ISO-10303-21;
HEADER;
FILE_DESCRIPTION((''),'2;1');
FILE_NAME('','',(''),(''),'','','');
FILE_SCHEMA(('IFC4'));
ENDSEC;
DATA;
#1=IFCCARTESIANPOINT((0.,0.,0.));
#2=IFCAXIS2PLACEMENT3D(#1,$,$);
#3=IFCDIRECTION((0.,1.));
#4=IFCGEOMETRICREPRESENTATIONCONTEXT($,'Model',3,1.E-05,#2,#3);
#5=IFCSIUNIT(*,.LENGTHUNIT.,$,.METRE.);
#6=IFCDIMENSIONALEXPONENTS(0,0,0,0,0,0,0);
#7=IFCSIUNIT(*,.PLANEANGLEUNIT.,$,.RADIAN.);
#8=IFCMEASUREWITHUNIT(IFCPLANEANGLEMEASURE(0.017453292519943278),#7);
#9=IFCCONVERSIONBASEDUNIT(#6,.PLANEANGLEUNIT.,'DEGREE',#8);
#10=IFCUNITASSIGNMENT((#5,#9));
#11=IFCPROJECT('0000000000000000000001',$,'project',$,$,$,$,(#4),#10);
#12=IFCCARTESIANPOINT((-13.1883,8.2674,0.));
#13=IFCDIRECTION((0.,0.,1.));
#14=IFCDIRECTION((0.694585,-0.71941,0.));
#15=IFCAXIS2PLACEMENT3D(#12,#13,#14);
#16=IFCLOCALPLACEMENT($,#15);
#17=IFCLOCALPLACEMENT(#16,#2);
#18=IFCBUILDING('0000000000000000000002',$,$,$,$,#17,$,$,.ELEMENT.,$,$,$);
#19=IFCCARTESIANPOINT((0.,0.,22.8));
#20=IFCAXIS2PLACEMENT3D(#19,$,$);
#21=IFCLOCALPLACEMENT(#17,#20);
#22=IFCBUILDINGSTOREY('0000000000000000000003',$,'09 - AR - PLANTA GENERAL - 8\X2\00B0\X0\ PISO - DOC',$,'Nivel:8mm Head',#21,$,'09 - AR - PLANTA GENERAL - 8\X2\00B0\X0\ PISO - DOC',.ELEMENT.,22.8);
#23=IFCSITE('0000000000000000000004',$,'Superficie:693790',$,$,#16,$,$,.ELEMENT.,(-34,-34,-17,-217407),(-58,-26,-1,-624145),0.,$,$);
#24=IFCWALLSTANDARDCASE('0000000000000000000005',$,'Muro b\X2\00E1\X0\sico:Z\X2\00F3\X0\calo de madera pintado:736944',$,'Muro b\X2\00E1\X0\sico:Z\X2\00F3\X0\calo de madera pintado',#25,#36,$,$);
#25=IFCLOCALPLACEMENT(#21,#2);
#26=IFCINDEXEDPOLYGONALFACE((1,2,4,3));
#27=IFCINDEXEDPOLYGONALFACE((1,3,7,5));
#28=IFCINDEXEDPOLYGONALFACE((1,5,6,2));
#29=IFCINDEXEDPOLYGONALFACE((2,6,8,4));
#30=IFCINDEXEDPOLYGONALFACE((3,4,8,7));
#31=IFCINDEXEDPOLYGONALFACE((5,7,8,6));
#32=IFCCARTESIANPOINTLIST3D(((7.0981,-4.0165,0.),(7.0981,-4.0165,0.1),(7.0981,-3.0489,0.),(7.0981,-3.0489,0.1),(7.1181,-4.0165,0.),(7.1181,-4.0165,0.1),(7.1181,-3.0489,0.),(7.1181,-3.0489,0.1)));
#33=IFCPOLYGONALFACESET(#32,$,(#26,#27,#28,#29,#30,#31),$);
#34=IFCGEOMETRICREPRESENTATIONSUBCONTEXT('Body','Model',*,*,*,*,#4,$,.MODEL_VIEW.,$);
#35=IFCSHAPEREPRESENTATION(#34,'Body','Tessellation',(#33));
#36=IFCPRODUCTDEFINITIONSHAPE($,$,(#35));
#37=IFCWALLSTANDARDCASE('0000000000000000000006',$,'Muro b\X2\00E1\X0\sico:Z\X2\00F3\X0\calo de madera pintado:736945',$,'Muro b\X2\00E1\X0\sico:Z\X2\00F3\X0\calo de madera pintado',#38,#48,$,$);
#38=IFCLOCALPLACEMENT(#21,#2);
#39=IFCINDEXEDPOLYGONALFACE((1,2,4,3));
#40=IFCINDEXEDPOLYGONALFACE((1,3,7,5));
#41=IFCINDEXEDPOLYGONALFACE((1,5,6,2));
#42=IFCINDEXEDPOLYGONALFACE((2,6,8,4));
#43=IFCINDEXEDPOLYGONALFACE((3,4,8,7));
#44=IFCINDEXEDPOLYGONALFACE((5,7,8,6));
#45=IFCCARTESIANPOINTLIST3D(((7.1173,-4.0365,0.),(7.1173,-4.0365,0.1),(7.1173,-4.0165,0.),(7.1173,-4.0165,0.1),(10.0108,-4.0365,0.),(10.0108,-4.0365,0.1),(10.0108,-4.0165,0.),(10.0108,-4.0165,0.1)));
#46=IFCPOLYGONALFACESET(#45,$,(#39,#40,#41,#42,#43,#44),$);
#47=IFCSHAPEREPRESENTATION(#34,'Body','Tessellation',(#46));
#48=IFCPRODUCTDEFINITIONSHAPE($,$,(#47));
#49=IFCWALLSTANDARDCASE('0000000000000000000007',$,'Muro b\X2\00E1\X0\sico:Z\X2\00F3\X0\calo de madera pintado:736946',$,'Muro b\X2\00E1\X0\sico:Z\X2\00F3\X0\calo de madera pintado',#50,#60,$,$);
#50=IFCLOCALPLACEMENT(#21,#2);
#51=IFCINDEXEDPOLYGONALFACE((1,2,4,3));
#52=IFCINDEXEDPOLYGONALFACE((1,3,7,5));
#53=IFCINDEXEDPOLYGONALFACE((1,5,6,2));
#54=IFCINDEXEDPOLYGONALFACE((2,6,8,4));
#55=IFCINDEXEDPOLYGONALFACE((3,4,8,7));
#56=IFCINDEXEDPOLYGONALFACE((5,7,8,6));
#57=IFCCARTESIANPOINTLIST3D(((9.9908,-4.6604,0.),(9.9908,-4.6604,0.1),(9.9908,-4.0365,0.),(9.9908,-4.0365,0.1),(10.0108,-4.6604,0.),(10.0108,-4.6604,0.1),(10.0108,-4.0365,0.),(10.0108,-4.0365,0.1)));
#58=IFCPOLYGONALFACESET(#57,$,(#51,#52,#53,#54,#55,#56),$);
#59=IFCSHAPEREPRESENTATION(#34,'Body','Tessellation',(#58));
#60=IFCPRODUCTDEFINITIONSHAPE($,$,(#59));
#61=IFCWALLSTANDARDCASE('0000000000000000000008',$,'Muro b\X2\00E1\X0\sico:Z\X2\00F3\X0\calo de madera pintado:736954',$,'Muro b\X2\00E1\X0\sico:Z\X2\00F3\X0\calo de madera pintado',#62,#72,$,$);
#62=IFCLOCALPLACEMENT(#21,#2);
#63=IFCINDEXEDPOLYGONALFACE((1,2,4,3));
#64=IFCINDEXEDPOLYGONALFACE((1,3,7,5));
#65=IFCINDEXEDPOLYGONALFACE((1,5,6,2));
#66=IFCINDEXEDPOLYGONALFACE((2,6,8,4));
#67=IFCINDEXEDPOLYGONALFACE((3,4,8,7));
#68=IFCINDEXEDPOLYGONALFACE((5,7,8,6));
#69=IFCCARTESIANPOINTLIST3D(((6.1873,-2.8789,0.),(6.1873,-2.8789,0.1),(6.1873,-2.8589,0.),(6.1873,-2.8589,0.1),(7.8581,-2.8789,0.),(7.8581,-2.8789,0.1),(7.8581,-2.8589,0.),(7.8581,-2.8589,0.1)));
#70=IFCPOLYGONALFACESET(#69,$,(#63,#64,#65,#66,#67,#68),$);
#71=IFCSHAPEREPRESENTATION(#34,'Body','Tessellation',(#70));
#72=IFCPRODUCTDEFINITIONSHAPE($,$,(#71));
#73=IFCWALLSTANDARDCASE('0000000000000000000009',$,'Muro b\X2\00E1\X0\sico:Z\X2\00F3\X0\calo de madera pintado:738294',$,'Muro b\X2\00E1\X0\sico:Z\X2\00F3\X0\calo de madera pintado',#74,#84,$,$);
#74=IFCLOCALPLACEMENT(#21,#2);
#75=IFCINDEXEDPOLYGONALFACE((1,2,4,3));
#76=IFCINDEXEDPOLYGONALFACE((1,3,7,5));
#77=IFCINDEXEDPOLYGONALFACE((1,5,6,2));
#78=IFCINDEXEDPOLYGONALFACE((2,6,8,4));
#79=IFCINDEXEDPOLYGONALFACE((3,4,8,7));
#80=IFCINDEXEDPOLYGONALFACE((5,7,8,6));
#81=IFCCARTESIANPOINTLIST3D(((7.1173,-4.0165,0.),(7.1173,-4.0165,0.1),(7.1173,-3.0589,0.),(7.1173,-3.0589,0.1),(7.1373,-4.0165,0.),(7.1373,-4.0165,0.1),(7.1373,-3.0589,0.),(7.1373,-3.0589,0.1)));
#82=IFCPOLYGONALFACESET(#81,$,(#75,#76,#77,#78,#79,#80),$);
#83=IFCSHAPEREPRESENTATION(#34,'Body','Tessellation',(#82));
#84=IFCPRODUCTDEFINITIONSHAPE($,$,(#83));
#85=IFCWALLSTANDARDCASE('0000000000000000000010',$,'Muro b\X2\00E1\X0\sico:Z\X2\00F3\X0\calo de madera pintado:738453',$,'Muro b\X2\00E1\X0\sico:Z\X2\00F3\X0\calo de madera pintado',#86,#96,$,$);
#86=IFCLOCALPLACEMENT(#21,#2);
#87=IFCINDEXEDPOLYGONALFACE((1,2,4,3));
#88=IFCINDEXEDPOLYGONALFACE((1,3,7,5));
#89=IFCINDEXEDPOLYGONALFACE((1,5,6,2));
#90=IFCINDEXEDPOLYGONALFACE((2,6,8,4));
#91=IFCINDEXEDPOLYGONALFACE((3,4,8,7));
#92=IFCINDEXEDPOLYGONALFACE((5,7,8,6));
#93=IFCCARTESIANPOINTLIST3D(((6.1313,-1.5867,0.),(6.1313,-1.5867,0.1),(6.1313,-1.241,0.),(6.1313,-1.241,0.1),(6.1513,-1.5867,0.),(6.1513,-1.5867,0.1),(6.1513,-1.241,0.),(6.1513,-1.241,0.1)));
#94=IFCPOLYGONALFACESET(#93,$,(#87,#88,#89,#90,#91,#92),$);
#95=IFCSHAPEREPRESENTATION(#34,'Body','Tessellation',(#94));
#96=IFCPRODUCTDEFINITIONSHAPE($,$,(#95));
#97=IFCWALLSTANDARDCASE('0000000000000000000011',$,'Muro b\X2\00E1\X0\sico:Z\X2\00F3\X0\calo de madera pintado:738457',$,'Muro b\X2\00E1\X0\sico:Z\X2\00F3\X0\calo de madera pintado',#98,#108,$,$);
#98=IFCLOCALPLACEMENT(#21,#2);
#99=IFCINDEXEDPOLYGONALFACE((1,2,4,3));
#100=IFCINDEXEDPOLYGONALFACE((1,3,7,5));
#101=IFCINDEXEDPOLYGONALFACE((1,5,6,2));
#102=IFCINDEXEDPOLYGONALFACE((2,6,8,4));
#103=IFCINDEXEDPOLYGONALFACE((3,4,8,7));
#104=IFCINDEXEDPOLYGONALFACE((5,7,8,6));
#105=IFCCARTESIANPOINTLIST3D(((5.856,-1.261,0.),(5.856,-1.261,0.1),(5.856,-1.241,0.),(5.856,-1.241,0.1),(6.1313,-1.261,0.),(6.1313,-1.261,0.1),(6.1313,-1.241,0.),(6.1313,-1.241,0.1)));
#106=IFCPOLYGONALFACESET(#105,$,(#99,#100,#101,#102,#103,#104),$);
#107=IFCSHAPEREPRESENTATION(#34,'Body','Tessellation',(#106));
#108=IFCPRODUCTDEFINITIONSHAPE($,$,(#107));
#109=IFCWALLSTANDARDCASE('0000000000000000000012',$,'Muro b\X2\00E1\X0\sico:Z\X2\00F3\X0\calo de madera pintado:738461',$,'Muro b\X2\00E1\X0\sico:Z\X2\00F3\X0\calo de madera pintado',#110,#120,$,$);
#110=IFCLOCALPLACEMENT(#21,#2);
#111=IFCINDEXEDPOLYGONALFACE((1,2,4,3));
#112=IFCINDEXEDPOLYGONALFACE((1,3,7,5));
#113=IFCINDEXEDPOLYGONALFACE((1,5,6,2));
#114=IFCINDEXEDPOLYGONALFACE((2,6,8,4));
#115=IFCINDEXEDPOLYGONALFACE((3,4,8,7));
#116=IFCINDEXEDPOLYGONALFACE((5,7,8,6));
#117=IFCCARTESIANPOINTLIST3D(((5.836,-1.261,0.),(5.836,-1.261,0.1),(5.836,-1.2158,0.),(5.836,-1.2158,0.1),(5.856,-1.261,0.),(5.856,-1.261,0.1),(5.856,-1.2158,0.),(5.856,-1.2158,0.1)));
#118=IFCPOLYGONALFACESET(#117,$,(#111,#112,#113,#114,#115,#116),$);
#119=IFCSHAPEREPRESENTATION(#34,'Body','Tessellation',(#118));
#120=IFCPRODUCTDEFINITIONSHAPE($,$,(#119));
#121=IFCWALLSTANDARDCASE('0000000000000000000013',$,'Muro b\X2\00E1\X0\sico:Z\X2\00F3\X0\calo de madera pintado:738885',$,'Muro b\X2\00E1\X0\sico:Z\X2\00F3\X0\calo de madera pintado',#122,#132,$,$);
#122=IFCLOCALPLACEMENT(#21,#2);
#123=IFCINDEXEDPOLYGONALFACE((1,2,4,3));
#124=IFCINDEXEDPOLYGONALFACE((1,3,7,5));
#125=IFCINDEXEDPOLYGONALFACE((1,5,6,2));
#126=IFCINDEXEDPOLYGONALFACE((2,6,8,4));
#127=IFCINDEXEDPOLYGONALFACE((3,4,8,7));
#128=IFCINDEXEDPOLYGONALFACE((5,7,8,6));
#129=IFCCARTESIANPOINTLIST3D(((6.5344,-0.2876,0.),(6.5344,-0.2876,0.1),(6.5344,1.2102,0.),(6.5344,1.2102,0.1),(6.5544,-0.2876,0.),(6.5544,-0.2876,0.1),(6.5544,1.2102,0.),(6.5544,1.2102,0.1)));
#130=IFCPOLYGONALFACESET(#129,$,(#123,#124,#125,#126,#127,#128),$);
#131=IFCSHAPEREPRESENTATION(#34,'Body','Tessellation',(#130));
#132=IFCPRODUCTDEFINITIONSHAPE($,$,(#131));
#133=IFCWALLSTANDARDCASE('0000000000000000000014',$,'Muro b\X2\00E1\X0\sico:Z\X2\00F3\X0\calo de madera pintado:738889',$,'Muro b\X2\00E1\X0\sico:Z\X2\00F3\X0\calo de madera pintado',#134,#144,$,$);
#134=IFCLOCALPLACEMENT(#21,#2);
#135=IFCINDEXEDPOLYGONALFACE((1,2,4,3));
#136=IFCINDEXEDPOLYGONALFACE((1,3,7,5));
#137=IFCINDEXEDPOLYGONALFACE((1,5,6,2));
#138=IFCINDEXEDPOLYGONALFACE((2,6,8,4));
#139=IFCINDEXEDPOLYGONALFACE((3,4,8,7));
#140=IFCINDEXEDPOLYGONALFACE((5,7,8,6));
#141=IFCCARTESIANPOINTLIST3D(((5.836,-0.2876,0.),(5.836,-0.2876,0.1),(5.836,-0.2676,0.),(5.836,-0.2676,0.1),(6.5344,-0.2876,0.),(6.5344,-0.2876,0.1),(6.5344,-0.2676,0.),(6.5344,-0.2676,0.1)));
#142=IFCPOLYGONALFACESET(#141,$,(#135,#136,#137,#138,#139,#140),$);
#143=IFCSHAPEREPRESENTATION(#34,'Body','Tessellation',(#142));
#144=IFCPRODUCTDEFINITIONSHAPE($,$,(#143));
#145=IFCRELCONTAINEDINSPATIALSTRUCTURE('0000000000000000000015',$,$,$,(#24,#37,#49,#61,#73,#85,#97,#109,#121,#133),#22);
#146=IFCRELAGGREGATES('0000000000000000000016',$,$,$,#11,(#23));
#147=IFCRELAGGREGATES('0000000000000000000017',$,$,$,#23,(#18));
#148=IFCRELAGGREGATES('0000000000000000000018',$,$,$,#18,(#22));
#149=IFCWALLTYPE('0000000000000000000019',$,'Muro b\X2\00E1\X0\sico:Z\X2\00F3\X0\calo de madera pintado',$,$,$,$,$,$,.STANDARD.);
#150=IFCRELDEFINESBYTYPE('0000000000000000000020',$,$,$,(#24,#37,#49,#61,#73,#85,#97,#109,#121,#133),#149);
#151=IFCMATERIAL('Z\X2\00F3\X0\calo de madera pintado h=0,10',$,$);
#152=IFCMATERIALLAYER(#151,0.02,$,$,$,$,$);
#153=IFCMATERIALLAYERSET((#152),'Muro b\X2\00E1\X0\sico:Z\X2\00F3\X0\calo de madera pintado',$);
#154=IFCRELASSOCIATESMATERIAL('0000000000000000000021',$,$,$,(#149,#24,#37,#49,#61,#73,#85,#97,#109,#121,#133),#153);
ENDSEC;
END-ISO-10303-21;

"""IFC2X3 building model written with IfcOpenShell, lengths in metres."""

from ifc_helpers import new_model, entity, si_unit, converted_unit, direction, frame, frame_2d, origin, place, context, subcontext, project, spatial, rectangle, extrude, material, layer, layer_set, layer_usage, type_object, element, save


model = new_model("IFC2X3")

# Units and contexts
model_context = context("Model", 3, precision=1e-05, world=origin(), true_north=direction((0.0, 1.0)))
body_context = subcontext(model_context, "Body", "Model", "MODEL_VIEW")
ifc_project = project(units=[si_unit("LENGTHUNIT", "METRE"), converted_unit("PLANEANGLEUNIT", "DEGREE", entity("IfcPlaneAngleMeasure", 0.017453292519943278), si_unit("PLANEANGLEUNIT", "RADIAN"), dimensions=[0, 0, 0, 0, 0, 0, 0])], contexts=[model_context])

# Site, building, storey
site_placement = place(None, frame((-13.1883, 8.2674, 0.0), z_axis=(0.0, 0.0, 1.0), x_axis=(0.694585, -0.71941, 0.0)))
site = spatial("IfcSite", under=ifc_project, at=site_placement, Name="Superficie:693790", CompositionType="ELEMENT", RefLatitude=(-34, -34, -17, -217407), RefLongitude=(-58, -26, -1, -624145), RefElevation=0.0)
building_placement = place(site_placement, origin())
building = spatial("IfcBuilding", under=site, at=building_placement, CompositionType="ELEMENT")
storey_placement = place(building_placement, frame((0.0, 0.0, 22.8)))
storey = spatial("IfcBuildingStorey", under=building, at=storey_placement, Name="09 - AR - PLANTA GENERAL - 8° PISO - DOC", ObjectType="Nivel:8mm Head", LongName="09 - AR - PLANTA GENERAL - 8° PISO - DOC", CompositionType="ELEMENT", Elevation=22.8)

# Walls
ifc_material_1 = material(Name="Zócalo de madera pintado h=0,10")
ifc_layer_1 = layer(ifc_material_1, 0.02)
ifc_layer_set_1 = layer_set([ifc_layer_1], Name="Muro básico:Zócalo de madera pintado")
wall_type_1 = type_object("IfcWallType", Name="Muro básico:Zócalo de madera pintado", PredefinedType="STANDARD", material=ifc_layer_set_1)
ifc_layer_usage_1 = layer_usage(ifc_layer_set_1, "AXIS2", "NEGATIVE", 0.01)
wall_1_placement = place(storey_placement, frame((7.1081, -4.0165, 0.0), z_axis=(0.0, 0.0, 1.0), x_axis=(0.0, 1.0, 0.0)))
element("IfcWallStandardCase", 1, at=wall_1_placement, inside=storey, type_object=wall_type_1, material=ifc_layer_usage_1, Name="Muro básico:Zócalo de madera pintado:736944", ObjectType="Muro básico:Zócalo de madera pintado", context=body_context, shape_type="SweptSolid", body=[
    extrude(rectangle(XDim=0.9676, YDim=0.02, at=frame_2d((0.4838, 0.0), x_axis=(-1.0, 0.0))), origin(), (0.0, 0.0, 1.0), 0.1),
])
ifc_layer_usage_2 = layer_usage(ifc_layer_set_1, "AXIS2", "NEGATIVE", 0.01)
wall_2_placement = place(storey_placement, frame((10.0108, -4.0265, 0.0), z_axis=(0.0, 0.0, 1.0), x_axis=(-1.0, 0.0, 0.0)))
element("IfcWallStandardCase", 2, at=wall_2_placement, inside=storey, type_object=wall_type_1, material=ifc_layer_usage_2, Name="Muro básico:Zócalo de madera pintado:736945", ObjectType="Muro básico:Zócalo de madera pintado", context=body_context, shape_type="SweptSolid", body=[
    extrude(rectangle(XDim=2.8934, YDim=0.02, at=frame_2d((1.4467, 0.0), x_axis=(-1.0, 0.0))), origin(), (0.0, 0.0, 1.0), 0.1),
])
ifc_layer_usage_3 = layer_usage(ifc_layer_set_1, "AXIS2", "NEGATIVE", 0.01)
wall_3_placement = place(storey_placement, frame((10.0008, -4.6604, 0.0), z_axis=(0.0, 0.0, 1.0), x_axis=(0.0, 1.0, 0.0)))
element("IfcWallStandardCase", 3, at=wall_3_placement, inside=storey, type_object=wall_type_1, material=ifc_layer_usage_3, Name="Muro básico:Zócalo de madera pintado:736946", ObjectType="Muro básico:Zócalo de madera pintado", context=body_context, shape_type="SweptSolid", body=[
    extrude(rectangle(XDim=0.6239, YDim=0.02, at=frame_2d((0.312, 0.0), x_axis=(-1.0, 0.0))), origin(), (0.0, 0.0, 1.0), 0.1),
])
ifc_layer_usage_4 = layer_usage(ifc_layer_set_1, "AXIS2", "NEGATIVE", 0.01)
wall_4_placement = place(storey_placement, frame((7.8581, -2.8689, 0.0), z_axis=(0.0, 0.0, 1.0), x_axis=(-1.0, 0.0, 0.0)))
element("IfcWallStandardCase", 4, at=wall_4_placement, inside=storey, type_object=wall_type_1, material=ifc_layer_usage_4, Name="Muro básico:Zócalo de madera pintado:736954", ObjectType="Muro básico:Zócalo de madera pintado", context=body_context, shape_type="SweptSolid", body=[
    extrude(rectangle(XDim=1.6707, YDim=0.02, at=frame_2d((0.8354, 0.0), x_axis=(-1.0, 0.0))), origin(), (0.0, 0.0, 1.0), 0.1),
])
ifc_layer_usage_5 = layer_usage(ifc_layer_set_1, "AXIS2", "NEGATIVE", 0.01)
wall_5_placement = place(storey_placement, frame((7.1273, -4.0165, 0.0), z_axis=(0.0, 0.0, 1.0), x_axis=(0.0, 1.0, 0.0)))
element("IfcWallStandardCase", 5, at=wall_5_placement, inside=storey, type_object=wall_type_1, material=ifc_layer_usage_5, Name="Muro básico:Zócalo de madera pintado:738294", ObjectType="Muro básico:Zócalo de madera pintado", context=body_context, shape_type="SweptSolid", body=[
    extrude(rectangle(XDim=0.9576, YDim=0.02, at=frame_2d((0.4788, 0.0), x_axis=(-1.0, 0.0))), origin(), (0.0, 0.0, 1.0), 0.1),
])
ifc_layer_usage_6 = layer_usage(ifc_layer_set_1, "AXIS2", "NEGATIVE", 0.01)
wall_6_placement = place(storey_placement, frame((6.1413, -1.5867, 0.0), z_axis=(0.0, 0.0, 1.0), x_axis=(0.0, 1.0, 0.0)))
element("IfcWallStandardCase", 6, at=wall_6_placement, inside=storey, type_object=wall_type_1, material=ifc_layer_usage_6, Name="Muro básico:Zócalo de madera pintado:738453", ObjectType="Muro básico:Zócalo de madera pintado", context=body_context, shape_type="SweptSolid", body=[
    extrude(rectangle(XDim=0.3457, YDim=0.02, at=frame_2d((0.1729, 0.0), x_axis=(-1.0, 0.0))), origin(), (0.0, 0.0, 1.0), 0.1),
])
ifc_layer_usage_7 = layer_usage(ifc_layer_set_1, "AXIS2", "NEGATIVE", 0.01)
wall_7_placement = place(storey_placement, frame((6.1313, -1.251, 0.0), z_axis=(0.0, 0.0, 1.0), x_axis=(-1.0, 0.0, 0.0)))
element("IfcWallStandardCase", 7, at=wall_7_placement, inside=storey, type_object=wall_type_1, material=ifc_layer_usage_7, Name="Muro básico:Zócalo de madera pintado:738457", ObjectType="Muro básico:Zócalo de madera pintado", context=body_context, shape_type="SweptSolid", body=[
    extrude(rectangle(XDim=0.2753, YDim=0.02, at=frame_2d((0.1376, 0.0), x_axis=(-1.0, 0.0))), origin(), (0.0, 0.0, 1.0), 0.1),
])
ifc_layer_usage_8 = layer_usage(ifc_layer_set_1, "AXIS2", "NEGATIVE", 0.01)
wall_8_placement = place(storey_placement, frame((5.846, -1.261, 0.0), z_axis=(0.0, 0.0, 1.0), x_axis=(0.0, 1.0, 0.0)))
element("IfcWallStandardCase", 8, at=wall_8_placement, inside=storey, type_object=wall_type_1, material=ifc_layer_usage_8, Name="Muro básico:Zócalo de madera pintado:738461", ObjectType="Muro básico:Zócalo de madera pintado", context=body_context, shape_type="SweptSolid", body=[
    extrude(rectangle(XDim=0.0452, YDim=0.02, at=frame_2d((0.0226, 0.0), x_axis=(-1.0, 0.0))), origin(), (0.0, 0.0, 1.0), 0.1),
])
ifc_layer_usage_9 = layer_usage(ifc_layer_set_1, "AXIS2", "NEGATIVE", 0.01)
wall_9_placement = place(storey_placement, frame((6.5444, -0.2876, 0.0), z_axis=(0.0, 0.0, 1.0), x_axis=(0.0, 1.0, 0.0)))
element("IfcWallStandardCase", 9, at=wall_9_placement, inside=storey, type_object=wall_type_1, material=ifc_layer_usage_9, Name="Muro básico:Zócalo de madera pintado:738885", ObjectType="Muro básico:Zócalo de madera pintado", context=body_context, shape_type="SweptSolid", body=[
    extrude(rectangle(XDim=1.4978, YDim=0.02, at=frame_2d((0.7489, 0.0), x_axis=(-1.0, 0.0))), origin(), (0.0, 0.0, 1.0), 0.1),
])
ifc_layer_usage_10 = layer_usage(ifc_layer_set_1, "AXIS2", "NEGATIVE", 0.01)
wall_10_placement = place(storey_placement, frame((5.836, -0.2776, 0.0)))
element("IfcWallStandardCase", 10, at=wall_10_placement, inside=storey, type_object=wall_type_1, material=ifc_layer_usage_10, Name="Muro básico:Zócalo de madera pintado:738889", ObjectType="Muro básico:Zócalo de madera pintado", context=body_context, shape_type="SweptSolid", body=[
    extrude(rectangle(XDim=0.6984, YDim=0.02, at=frame_2d((0.3492, 0.0), x_axis=(-1.0, 0.0))), origin(), (0.0, 0.0, 1.0), 0.1),
])

save(model, "model.ifc")
